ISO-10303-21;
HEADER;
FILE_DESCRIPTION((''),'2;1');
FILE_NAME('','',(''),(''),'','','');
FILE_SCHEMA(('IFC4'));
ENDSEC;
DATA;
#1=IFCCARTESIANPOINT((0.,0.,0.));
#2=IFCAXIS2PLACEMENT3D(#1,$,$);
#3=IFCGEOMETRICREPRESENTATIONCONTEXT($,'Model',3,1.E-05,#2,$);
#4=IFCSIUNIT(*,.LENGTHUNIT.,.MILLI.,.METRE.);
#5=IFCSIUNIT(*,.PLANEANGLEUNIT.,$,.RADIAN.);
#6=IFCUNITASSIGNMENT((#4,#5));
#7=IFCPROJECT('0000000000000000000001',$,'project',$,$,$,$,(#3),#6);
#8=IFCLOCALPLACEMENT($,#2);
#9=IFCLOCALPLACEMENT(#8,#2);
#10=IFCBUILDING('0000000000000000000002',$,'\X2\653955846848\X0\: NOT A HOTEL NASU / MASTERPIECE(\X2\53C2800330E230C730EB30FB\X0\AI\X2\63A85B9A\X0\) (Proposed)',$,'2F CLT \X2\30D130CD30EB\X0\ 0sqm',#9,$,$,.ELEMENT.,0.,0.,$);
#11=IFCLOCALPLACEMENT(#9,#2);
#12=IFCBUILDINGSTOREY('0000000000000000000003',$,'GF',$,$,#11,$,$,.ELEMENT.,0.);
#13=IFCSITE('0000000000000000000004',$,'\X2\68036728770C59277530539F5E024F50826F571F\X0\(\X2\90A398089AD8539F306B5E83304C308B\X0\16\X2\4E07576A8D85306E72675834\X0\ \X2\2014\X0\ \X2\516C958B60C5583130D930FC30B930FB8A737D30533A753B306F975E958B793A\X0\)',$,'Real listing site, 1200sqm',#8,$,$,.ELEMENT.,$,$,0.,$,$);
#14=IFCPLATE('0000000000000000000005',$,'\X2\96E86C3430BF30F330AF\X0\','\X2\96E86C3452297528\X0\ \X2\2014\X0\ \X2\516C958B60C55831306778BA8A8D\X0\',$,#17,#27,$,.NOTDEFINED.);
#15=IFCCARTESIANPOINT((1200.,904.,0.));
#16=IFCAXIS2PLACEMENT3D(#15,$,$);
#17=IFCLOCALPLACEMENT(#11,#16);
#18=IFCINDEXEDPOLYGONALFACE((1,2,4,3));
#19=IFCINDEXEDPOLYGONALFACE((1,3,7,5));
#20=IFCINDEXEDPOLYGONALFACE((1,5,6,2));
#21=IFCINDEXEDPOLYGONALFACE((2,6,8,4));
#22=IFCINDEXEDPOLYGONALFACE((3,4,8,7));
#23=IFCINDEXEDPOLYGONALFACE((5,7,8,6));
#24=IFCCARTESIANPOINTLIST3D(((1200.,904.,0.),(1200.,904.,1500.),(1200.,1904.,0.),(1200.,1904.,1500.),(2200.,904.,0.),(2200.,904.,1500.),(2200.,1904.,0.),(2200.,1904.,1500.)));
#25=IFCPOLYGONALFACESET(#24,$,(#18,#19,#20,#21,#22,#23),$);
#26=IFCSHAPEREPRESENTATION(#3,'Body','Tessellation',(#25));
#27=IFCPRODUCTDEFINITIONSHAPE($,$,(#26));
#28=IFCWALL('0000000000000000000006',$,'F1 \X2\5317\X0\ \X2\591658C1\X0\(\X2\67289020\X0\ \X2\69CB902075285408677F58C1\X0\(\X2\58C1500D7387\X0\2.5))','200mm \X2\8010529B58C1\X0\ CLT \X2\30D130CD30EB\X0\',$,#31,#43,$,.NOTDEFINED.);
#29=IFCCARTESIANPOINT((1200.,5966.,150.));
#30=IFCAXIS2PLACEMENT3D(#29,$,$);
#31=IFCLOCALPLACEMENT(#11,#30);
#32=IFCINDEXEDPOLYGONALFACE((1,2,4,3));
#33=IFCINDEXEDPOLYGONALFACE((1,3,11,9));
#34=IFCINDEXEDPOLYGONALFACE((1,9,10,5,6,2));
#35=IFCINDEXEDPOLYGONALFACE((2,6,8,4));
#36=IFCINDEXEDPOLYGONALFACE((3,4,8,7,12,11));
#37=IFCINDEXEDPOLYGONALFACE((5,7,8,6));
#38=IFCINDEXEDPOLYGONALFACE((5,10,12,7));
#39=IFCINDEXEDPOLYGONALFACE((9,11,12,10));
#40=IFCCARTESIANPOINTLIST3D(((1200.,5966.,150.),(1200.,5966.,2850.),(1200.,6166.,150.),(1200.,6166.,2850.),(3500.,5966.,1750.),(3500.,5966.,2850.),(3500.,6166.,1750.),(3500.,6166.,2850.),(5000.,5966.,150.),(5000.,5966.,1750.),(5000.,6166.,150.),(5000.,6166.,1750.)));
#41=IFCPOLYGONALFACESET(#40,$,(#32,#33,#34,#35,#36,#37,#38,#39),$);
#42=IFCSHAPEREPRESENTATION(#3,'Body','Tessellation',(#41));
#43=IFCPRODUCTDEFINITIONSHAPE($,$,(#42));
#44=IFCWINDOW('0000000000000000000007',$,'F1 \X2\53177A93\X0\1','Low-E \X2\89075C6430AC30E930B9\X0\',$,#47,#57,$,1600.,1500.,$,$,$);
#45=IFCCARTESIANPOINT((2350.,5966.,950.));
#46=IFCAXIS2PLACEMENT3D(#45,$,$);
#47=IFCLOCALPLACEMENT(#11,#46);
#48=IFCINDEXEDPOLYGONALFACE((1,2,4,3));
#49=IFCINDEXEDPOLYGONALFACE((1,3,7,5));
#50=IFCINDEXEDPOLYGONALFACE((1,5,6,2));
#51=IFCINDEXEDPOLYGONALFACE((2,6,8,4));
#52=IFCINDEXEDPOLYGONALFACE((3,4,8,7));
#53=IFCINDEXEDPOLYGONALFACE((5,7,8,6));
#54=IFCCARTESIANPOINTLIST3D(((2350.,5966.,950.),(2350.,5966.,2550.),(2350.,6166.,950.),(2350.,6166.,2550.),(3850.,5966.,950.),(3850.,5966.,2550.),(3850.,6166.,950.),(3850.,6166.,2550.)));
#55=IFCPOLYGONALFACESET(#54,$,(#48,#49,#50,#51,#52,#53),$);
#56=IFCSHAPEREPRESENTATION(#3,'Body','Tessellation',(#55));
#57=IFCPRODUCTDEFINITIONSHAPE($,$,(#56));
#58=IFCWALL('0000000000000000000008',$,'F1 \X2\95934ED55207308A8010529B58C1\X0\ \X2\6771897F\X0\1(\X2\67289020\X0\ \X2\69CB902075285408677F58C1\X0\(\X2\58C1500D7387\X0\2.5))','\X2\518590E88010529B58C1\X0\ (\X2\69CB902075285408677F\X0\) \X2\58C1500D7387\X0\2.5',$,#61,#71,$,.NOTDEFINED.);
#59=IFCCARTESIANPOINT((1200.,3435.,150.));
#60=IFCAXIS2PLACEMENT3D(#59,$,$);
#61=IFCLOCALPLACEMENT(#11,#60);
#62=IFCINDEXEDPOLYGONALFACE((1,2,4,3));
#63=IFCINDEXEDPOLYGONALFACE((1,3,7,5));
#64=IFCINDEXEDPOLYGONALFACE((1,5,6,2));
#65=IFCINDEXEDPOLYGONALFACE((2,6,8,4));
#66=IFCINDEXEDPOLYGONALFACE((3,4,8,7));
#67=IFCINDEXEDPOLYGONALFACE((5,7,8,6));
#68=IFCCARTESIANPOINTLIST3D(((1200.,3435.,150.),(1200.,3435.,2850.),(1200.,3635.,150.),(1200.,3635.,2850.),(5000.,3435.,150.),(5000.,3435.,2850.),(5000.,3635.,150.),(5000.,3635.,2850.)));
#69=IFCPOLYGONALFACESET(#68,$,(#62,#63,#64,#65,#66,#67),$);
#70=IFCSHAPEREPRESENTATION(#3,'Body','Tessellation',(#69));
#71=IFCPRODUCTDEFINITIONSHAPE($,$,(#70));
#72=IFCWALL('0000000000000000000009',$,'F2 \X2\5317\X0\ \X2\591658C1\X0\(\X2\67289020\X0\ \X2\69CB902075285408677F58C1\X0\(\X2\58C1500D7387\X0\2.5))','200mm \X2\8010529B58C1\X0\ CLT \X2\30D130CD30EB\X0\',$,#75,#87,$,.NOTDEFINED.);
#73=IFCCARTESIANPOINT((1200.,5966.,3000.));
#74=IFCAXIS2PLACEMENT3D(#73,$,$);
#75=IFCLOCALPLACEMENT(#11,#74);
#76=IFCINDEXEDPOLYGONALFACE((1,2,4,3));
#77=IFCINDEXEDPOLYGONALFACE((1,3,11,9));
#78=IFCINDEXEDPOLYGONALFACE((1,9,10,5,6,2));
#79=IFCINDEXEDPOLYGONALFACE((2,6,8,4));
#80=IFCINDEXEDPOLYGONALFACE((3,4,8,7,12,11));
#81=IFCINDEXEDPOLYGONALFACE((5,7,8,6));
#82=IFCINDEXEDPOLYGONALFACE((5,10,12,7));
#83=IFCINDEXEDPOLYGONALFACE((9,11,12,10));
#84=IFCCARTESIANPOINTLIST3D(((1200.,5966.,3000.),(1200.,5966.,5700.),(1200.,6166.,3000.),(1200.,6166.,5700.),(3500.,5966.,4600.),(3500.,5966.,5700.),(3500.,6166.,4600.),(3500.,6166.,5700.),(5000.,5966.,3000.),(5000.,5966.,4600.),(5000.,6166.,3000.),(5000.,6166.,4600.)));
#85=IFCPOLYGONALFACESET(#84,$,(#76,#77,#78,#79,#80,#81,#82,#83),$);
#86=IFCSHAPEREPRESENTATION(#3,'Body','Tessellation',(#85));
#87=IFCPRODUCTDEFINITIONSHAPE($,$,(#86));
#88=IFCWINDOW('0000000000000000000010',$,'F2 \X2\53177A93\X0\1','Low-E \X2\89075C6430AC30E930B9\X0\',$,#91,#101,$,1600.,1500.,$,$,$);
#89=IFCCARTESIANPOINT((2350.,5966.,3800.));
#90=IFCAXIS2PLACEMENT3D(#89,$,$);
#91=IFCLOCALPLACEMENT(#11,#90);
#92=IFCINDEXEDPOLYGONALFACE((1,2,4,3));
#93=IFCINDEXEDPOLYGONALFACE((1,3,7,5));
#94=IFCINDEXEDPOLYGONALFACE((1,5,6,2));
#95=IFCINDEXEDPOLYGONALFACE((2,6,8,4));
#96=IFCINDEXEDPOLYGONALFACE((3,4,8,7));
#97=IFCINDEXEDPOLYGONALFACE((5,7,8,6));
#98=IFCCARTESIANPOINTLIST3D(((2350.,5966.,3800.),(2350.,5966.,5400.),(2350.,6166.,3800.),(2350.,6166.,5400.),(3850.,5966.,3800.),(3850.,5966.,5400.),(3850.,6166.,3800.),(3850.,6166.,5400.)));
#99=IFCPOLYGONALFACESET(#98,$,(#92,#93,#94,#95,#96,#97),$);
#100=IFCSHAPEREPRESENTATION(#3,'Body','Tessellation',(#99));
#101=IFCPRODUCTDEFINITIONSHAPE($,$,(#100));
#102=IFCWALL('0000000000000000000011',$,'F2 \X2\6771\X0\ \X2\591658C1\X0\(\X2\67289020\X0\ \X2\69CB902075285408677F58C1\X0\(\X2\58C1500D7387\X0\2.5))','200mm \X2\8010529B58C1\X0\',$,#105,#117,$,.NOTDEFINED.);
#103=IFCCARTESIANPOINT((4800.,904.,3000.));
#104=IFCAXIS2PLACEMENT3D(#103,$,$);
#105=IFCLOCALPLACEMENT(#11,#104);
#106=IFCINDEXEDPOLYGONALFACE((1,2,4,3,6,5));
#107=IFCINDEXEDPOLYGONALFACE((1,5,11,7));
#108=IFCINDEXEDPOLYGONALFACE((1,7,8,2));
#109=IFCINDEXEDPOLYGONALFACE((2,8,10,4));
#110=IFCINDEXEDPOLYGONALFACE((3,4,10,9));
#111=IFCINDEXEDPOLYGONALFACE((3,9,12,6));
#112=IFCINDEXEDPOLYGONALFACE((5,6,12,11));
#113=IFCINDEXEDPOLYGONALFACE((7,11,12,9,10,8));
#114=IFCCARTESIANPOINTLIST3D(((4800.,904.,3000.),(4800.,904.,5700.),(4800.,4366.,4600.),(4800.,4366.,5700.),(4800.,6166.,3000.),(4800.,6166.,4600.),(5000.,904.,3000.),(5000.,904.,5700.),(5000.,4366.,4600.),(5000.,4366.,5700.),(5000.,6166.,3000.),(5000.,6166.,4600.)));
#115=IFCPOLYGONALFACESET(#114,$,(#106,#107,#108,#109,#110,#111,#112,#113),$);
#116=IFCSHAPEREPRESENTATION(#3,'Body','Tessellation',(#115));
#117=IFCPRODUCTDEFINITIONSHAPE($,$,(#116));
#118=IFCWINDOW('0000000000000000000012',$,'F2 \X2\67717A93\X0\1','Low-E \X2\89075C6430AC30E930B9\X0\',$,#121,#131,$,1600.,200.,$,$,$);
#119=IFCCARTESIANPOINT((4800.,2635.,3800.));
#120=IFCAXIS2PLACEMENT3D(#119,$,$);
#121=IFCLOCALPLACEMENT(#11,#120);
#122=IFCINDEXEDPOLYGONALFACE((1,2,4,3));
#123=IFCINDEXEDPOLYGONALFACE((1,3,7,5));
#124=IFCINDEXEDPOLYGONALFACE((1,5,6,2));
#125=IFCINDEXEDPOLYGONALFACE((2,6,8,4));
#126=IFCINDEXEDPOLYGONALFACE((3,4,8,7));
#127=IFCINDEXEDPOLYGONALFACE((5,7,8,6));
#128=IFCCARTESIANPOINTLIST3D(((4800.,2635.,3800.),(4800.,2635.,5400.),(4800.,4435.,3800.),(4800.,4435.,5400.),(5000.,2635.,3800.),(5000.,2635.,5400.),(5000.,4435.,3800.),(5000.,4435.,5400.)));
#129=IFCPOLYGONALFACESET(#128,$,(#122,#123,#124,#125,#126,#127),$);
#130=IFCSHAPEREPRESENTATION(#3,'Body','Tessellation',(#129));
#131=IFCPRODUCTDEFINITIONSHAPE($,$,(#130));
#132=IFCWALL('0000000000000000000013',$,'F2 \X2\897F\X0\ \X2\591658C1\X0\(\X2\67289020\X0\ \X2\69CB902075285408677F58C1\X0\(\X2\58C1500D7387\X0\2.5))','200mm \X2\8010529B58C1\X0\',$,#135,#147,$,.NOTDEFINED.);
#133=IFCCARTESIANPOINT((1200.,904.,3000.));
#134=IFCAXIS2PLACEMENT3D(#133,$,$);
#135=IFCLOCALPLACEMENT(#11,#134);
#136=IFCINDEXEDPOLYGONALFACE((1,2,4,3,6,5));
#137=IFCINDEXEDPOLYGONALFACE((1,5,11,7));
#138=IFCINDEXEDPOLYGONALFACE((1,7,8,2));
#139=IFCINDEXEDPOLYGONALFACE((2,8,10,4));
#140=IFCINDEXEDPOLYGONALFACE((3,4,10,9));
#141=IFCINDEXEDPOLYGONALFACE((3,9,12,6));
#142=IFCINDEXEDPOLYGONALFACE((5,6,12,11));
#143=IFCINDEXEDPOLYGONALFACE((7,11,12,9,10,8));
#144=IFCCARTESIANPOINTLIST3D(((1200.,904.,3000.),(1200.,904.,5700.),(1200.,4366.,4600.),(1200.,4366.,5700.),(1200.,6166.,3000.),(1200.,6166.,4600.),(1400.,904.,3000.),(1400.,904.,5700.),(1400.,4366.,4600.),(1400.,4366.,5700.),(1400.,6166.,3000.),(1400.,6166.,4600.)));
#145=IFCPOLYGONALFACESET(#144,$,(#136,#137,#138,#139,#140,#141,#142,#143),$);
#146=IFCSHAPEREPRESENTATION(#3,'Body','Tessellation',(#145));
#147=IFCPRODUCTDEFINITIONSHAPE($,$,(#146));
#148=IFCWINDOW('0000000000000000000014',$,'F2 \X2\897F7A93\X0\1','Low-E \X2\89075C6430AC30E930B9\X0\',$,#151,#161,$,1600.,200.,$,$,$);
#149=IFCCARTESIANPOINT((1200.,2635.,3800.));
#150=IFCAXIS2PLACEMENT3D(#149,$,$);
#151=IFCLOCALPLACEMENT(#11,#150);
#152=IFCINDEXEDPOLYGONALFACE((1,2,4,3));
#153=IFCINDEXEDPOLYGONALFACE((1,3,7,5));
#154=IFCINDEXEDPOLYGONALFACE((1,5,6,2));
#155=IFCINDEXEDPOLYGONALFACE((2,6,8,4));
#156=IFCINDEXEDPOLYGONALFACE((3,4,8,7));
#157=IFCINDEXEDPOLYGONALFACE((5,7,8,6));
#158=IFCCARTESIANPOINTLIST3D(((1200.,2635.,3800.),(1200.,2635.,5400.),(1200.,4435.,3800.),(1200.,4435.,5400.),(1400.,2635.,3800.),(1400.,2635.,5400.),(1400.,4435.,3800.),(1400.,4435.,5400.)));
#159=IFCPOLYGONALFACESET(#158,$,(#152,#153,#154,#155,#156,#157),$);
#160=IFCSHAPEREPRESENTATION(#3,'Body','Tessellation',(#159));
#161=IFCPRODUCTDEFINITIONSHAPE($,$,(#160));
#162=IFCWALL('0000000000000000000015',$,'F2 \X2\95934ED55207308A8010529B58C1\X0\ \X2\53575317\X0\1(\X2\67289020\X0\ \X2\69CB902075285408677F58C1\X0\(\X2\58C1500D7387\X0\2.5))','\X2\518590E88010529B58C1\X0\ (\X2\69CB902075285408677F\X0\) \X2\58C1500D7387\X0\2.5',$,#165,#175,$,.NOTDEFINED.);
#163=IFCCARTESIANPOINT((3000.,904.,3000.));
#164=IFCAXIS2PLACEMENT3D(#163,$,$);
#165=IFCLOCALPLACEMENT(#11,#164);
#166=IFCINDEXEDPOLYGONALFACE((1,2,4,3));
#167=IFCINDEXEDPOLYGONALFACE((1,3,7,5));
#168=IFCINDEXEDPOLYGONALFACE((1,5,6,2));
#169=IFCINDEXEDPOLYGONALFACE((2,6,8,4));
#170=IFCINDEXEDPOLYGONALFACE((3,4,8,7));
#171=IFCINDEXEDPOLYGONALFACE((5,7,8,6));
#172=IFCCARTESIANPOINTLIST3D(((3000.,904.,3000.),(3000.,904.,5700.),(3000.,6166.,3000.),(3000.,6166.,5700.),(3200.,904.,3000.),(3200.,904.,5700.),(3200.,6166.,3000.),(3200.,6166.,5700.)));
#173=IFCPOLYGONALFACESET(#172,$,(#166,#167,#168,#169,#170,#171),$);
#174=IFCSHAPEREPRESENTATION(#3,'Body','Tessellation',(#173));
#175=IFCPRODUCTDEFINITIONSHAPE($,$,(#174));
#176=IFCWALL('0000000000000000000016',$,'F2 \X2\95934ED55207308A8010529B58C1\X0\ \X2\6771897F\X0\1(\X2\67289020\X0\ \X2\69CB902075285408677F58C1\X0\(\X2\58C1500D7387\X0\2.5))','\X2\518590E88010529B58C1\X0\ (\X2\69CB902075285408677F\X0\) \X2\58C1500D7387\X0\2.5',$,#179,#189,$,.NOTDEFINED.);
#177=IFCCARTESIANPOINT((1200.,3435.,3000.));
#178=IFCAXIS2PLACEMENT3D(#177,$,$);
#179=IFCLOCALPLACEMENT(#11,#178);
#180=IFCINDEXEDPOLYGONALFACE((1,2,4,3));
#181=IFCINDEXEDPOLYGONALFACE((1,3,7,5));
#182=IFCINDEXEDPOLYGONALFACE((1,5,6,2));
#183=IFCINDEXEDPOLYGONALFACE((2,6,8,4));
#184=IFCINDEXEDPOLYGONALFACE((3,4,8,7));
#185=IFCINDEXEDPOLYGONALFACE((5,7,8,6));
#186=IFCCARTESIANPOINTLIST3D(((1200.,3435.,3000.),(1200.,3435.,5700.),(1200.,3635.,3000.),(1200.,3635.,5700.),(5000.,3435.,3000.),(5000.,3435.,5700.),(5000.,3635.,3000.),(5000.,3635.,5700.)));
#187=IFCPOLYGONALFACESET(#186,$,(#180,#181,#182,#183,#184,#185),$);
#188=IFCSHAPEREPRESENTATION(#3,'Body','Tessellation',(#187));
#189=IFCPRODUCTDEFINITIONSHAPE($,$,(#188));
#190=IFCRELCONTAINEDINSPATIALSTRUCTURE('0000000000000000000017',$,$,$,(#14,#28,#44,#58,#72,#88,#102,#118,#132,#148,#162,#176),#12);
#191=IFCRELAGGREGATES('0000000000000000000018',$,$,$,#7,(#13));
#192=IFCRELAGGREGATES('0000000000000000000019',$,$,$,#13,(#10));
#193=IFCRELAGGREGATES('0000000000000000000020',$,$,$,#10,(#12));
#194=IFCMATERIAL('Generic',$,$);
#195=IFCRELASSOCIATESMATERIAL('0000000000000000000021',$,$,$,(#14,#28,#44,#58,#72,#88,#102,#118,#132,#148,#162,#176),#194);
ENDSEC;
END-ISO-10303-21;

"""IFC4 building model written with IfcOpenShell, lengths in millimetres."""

from ifc_helpers import new_model, si_unit, frame, frame_2d, origin, place, context, project, spatial, rectangle, extrude, material, element, fill, save


model = new_model("IFC4")

# Units and contexts
model_context = context("Model", 3, precision=1e-05, world=origin())
ifc_project = project(units=[si_unit("LENGTHUNIT", "METRE", prefix="MILLI"), si_unit("PLANEANGLEUNIT", "RADIAN")], contexts=[model_context])

# Site, building, storey
site_placement = place(None, origin())
site = spatial("IfcSite", under=ifc_project, at=site_placement, Name="栃木県大田原市佐良土(那須高原に広がる16万坪超の牧場 — 公開情報ベース・詳細区画は非開示)", ObjectType="Real listing site, 1200sqm", CompositionType="ELEMENT", RefElevation=0.0)
building_placement = place(site_placement, origin())
building = spatial("IfcBuilding", under=site, at=building_placement, Name="改善案: NOT A HOTEL NASU / MASTERPIECE(参考モデル・AI推定) (Proposed)", ObjectType="2F CLT パネル 0sqm", CompositionType="ELEMENT", ElevationOfRefHeight=0.0, ElevationOfTerrain=0.0)
storey_placement = place(building_placement, origin())
storey = spatial("IfcBuildingStorey", under=building, at=storey_placement, Name="GF", CompositionType="ELEMENT", Elevation=0.0)

# Plate
ifc_material_1 = material(Name="Generic")
plate_placement = place(storey_placement, frame((1200.0, 904.0, 0.0)))
element("IfcPlate", 1, at=plate_placement, inside=storey, material=ifc_material_1, Name="雨水タンク", Description="雨水利用 — 公開情報で確認", PredefinedType="NOTDEFINED", context=model_context, shape_type="SweptSolid", body=[
    extrude(rectangle(XDim=1000.0, YDim=1000.0, at=frame_2d((500.0, 500.0))), frame((1200.0, 904.0, 0.0)), (0.0, 0.0, 1.0), 1500.0),
])

# Wall, opening, window
wall_1_placement = place(storey_placement, frame((1200.0, 5966.0, 150.0)))
wall_1 = element("IfcWall", 2, at=wall_1_placement, inside=storey, material=ifc_material_1, Name="F1 北 外壁(木造 構造用合板壁(壁倍率2.5))", Description="200mm 耐力壁 CLT パネル", PredefinedType="NOTDEFINED", context=model_context, shape_type="SweptSolid", body=[
    extrude(rectangle(XDim=3800.0, YDim=200.0, at=frame_2d((1900.0, 100.0))), frame((1200.0, 5966.0, 150.0)), (0.0, 0.0, 1.0), 2700.0),
])
opening_1_placement = place(storey_placement, frame((2350.0, 5966.0, 950.0)))
opening_1 = element("IfcOpeningElement", 3, at=opening_1_placement, cuts=wall_1, PredefinedType="NOTDEFINED", context=model_context, shape_type="SweptSolid", body=[
    extrude(rectangle(XDim=1500.0, YDim=200.0, at=frame_2d((750.0, 100.0))), frame((2350.0, 5966.0, 950.0)), (0.0, 0.0, 1.0), 1600.0),
])
window_1_placement = place(storey_placement, frame((2350.0, 5966.0, 950.0)))
window_1 = element("IfcWindow", 4, at=window_1_placement, inside=storey, material=ifc_material_1, Name="F1 北窓1", Description="Low-E 複層ガラス", OverallHeight=1600.0, OverallWidth=1500.0, context=model_context, shape_type="SweptSolid", body=[
    extrude(rectangle(XDim=1500.0, YDim=200.0, at=frame_2d((750.0, 100.0))), frame((2350.0, 5966.0, 950.0)), (0.0, 0.0, 1.0), 1600.0),
])
fill(opening_1, window_1)

# Wall
wall_2_placement = place(storey_placement, frame((1200.0, 3435.0, 150.0)))
element("IfcWall", 5, at=wall_2_placement, inside=storey, material=ifc_material_1, Name="F1 間仕切り耐力壁 東西1(木造 構造用合板壁(壁倍率2.5))", Description="内部耐力壁 (構造用合板) 壁倍率2.5", PredefinedType="NOTDEFINED", context=model_context, shape_type="SweptSolid", body=[
    extrude(rectangle(XDim=3800.0, YDim=200.0, at=frame_2d((1900.0, 100.0))), frame((1200.0, 3435.0, 150.0)), (0.0, 0.0, 1.0), 2700.0),
])

# Walls, openings, windows
wall_3_placement = place(storey_placement, frame((1200.0, 5966.0, 3000.0)))
wall_3 = element("IfcWall", 6, at=wall_3_placement, inside=storey, material=ifc_material_1, Name="F2 北 外壁(木造 構造用合板壁(壁倍率2.5))", Description="200mm 耐力壁 CLT パネル", PredefinedType="NOTDEFINED", context=model_context, shape_type="SweptSolid", body=[
    extrude(rectangle(XDim=3800.0, YDim=200.0, at=frame_2d((1900.0, 100.0))), frame((1200.0, 5966.0, 3000.0)), (0.0, 0.0, 1.0), 2700.0),
])
opening_2_placement = place(storey_placement, frame((2350.0, 5966.0, 3800.0)))
opening_2 = element("IfcOpeningElement", 7, at=opening_2_placement, cuts=wall_3, PredefinedType="NOTDEFINED", context=model_context, shape_type="SweptSolid", body=[
    extrude(rectangle(XDim=1500.0, YDim=200.0, at=frame_2d((750.0, 100.0))), frame((2350.0, 5966.0, 3800.0)), (0.0, 0.0, 1.0), 1600.0),
])
window_2_placement = place(storey_placement, frame((2350.0, 5966.0, 3800.0)))
window_2 = element("IfcWindow", 8, at=window_2_placement, inside=storey, material=ifc_material_1, Name="F2 北窓1", Description="Low-E 複層ガラス", OverallHeight=1600.0, OverallWidth=1500.0, context=model_context, shape_type="SweptSolid", body=[
    extrude(rectangle(XDim=1500.0, YDim=200.0, at=frame_2d((750.0, 100.0))), frame((2350.0, 5966.0, 3800.0)), (0.0, 0.0, 1.0), 1600.0),
])
fill(opening_2, window_2)
wall_4_placement = place(storey_placement, frame((4800.0, 904.0, 3000.0)))
wall_4 = element("IfcWall", 9, at=wall_4_placement, inside=storey, material=ifc_material_1, Name="F2 東 外壁(木造 構造用合板壁(壁倍率2.5))", Description="200mm 耐力壁", PredefinedType="NOTDEFINED", context=model_context, shape_type="SweptSolid", body=[
    extrude(rectangle(XDim=200.0, YDim=5262.0, at=frame_2d((100.0, 2631.0))), frame((4800.0, 904.0, 3000.0)), (0.0, 0.0, 1.0), 2700.0),
])
opening_3_placement = place(storey_placement, frame((4800.0, 2635.0, 3800.0)))
opening_3 = element("IfcOpeningElement", 10, at=opening_3_placement, cuts=wall_4, PredefinedType="NOTDEFINED", context=model_context, shape_type="SweptSolid", body=[
    extrude(rectangle(XDim=200.0, YDim=1800.0, at=frame_2d((100.0, 900.0))), frame((4800.0, 2635.0, 3800.0)), (0.0, 0.0, 1.0), 1600.0),
])
window_3_placement = place(storey_placement, frame((4800.0, 2635.0, 3800.0)))
window_3 = element("IfcWindow", 11, at=window_3_placement, inside=storey, material=ifc_material_1, Name="F2 東窓1", Description="Low-E 複層ガラス", OverallHeight=1600.0, OverallWidth=200.0, context=model_context, shape_type="SweptSolid", body=[
    extrude(rectangle(XDim=200.0, YDim=1800.0, at=frame_2d((100.0, 900.0))), frame((4800.0, 2635.0, 3800.0)), (0.0, 0.0, 1.0), 1600.0),
])
fill(opening_3, window_3)
wall_5_placement = place(storey_placement, frame((1200.0, 904.0, 3000.0)))
wall_5 = element("IfcWall", 12, at=wall_5_placement, inside=storey, material=ifc_material_1, Name="F2 西 外壁(木造 構造用合板壁(壁倍率2.5))", Description="200mm 耐力壁", PredefinedType="NOTDEFINED", context=model_context, shape_type="SweptSolid", body=[
    extrude(rectangle(XDim=200.0, YDim=5262.0, at=frame_2d((100.0, 2631.0))), frame((1200.0, 904.0, 3000.0)), (0.0, 0.0, 1.0), 2700.0),
])
opening_4_placement = place(storey_placement, frame((1200.0, 2635.0, 3800.0)))
opening_4 = element("IfcOpeningElement", 13, at=opening_4_placement, cuts=wall_5, PredefinedType="NOTDEFINED", context=model_context, shape_type="SweptSolid", body=[
    extrude(rectangle(XDim=200.0, YDim=1800.0, at=frame_2d((100.0, 900.0))), frame((1200.0, 2635.0, 3800.0)), (0.0, 0.0, 1.0), 1600.0),
])
window_4_placement = place(storey_placement, frame((1200.0, 2635.0, 3800.0)))
window_4 = element("IfcWindow", 14, at=window_4_placement, inside=storey, material=ifc_material_1, Name="F2 西窓1", Description="Low-E 複層ガラス", OverallHeight=1600.0, OverallWidth=200.0, context=model_context, shape_type="SweptSolid", body=[
    extrude(rectangle(XDim=200.0, YDim=1800.0, at=frame_2d((100.0, 900.0))), frame((1200.0, 2635.0, 3800.0)), (0.0, 0.0, 1.0), 1600.0),
])
fill(opening_4, window_4)

# Walls
wall_6_placement = place(storey_placement, frame((3000.0, 904.0, 3000.0)))
element("IfcWall", 15, at=wall_6_placement, inside=storey, material=ifc_material_1, Name="F2 間仕切り耐力壁 南北1(木造 構造用合板壁(壁倍率2.5))", Description="内部耐力壁 (構造用合板) 壁倍率2.5", PredefinedType="NOTDEFINED", context=model_context, shape_type="SweptSolid", body=[
    extrude(rectangle(XDim=200.0, YDim=5262.0, at=frame_2d((100.0, 2631.0))), frame((3000.0, 904.0, 3000.0)), (0.0, 0.0, 1.0), 2700.0),
])
wall_7_placement = place(storey_placement, frame((1200.0, 3435.0, 3000.0)))
element("IfcWall", 16, at=wall_7_placement, inside=storey, material=ifc_material_1, Name="F2 間仕切り耐力壁 東西1(木造 構造用合板壁(壁倍率2.5))", Description="内部耐力壁 (構造用合板) 壁倍率2.5", PredefinedType="NOTDEFINED", context=model_context, shape_type="SweptSolid", body=[
    extrude(rectangle(XDim=3800.0, YDim=200.0, at=frame_2d((1900.0, 100.0))), frame((1200.0, 3435.0, 3000.0)), (0.0, 0.0, 1.0), 2700.0),
])

save(model, "model.ifc")
